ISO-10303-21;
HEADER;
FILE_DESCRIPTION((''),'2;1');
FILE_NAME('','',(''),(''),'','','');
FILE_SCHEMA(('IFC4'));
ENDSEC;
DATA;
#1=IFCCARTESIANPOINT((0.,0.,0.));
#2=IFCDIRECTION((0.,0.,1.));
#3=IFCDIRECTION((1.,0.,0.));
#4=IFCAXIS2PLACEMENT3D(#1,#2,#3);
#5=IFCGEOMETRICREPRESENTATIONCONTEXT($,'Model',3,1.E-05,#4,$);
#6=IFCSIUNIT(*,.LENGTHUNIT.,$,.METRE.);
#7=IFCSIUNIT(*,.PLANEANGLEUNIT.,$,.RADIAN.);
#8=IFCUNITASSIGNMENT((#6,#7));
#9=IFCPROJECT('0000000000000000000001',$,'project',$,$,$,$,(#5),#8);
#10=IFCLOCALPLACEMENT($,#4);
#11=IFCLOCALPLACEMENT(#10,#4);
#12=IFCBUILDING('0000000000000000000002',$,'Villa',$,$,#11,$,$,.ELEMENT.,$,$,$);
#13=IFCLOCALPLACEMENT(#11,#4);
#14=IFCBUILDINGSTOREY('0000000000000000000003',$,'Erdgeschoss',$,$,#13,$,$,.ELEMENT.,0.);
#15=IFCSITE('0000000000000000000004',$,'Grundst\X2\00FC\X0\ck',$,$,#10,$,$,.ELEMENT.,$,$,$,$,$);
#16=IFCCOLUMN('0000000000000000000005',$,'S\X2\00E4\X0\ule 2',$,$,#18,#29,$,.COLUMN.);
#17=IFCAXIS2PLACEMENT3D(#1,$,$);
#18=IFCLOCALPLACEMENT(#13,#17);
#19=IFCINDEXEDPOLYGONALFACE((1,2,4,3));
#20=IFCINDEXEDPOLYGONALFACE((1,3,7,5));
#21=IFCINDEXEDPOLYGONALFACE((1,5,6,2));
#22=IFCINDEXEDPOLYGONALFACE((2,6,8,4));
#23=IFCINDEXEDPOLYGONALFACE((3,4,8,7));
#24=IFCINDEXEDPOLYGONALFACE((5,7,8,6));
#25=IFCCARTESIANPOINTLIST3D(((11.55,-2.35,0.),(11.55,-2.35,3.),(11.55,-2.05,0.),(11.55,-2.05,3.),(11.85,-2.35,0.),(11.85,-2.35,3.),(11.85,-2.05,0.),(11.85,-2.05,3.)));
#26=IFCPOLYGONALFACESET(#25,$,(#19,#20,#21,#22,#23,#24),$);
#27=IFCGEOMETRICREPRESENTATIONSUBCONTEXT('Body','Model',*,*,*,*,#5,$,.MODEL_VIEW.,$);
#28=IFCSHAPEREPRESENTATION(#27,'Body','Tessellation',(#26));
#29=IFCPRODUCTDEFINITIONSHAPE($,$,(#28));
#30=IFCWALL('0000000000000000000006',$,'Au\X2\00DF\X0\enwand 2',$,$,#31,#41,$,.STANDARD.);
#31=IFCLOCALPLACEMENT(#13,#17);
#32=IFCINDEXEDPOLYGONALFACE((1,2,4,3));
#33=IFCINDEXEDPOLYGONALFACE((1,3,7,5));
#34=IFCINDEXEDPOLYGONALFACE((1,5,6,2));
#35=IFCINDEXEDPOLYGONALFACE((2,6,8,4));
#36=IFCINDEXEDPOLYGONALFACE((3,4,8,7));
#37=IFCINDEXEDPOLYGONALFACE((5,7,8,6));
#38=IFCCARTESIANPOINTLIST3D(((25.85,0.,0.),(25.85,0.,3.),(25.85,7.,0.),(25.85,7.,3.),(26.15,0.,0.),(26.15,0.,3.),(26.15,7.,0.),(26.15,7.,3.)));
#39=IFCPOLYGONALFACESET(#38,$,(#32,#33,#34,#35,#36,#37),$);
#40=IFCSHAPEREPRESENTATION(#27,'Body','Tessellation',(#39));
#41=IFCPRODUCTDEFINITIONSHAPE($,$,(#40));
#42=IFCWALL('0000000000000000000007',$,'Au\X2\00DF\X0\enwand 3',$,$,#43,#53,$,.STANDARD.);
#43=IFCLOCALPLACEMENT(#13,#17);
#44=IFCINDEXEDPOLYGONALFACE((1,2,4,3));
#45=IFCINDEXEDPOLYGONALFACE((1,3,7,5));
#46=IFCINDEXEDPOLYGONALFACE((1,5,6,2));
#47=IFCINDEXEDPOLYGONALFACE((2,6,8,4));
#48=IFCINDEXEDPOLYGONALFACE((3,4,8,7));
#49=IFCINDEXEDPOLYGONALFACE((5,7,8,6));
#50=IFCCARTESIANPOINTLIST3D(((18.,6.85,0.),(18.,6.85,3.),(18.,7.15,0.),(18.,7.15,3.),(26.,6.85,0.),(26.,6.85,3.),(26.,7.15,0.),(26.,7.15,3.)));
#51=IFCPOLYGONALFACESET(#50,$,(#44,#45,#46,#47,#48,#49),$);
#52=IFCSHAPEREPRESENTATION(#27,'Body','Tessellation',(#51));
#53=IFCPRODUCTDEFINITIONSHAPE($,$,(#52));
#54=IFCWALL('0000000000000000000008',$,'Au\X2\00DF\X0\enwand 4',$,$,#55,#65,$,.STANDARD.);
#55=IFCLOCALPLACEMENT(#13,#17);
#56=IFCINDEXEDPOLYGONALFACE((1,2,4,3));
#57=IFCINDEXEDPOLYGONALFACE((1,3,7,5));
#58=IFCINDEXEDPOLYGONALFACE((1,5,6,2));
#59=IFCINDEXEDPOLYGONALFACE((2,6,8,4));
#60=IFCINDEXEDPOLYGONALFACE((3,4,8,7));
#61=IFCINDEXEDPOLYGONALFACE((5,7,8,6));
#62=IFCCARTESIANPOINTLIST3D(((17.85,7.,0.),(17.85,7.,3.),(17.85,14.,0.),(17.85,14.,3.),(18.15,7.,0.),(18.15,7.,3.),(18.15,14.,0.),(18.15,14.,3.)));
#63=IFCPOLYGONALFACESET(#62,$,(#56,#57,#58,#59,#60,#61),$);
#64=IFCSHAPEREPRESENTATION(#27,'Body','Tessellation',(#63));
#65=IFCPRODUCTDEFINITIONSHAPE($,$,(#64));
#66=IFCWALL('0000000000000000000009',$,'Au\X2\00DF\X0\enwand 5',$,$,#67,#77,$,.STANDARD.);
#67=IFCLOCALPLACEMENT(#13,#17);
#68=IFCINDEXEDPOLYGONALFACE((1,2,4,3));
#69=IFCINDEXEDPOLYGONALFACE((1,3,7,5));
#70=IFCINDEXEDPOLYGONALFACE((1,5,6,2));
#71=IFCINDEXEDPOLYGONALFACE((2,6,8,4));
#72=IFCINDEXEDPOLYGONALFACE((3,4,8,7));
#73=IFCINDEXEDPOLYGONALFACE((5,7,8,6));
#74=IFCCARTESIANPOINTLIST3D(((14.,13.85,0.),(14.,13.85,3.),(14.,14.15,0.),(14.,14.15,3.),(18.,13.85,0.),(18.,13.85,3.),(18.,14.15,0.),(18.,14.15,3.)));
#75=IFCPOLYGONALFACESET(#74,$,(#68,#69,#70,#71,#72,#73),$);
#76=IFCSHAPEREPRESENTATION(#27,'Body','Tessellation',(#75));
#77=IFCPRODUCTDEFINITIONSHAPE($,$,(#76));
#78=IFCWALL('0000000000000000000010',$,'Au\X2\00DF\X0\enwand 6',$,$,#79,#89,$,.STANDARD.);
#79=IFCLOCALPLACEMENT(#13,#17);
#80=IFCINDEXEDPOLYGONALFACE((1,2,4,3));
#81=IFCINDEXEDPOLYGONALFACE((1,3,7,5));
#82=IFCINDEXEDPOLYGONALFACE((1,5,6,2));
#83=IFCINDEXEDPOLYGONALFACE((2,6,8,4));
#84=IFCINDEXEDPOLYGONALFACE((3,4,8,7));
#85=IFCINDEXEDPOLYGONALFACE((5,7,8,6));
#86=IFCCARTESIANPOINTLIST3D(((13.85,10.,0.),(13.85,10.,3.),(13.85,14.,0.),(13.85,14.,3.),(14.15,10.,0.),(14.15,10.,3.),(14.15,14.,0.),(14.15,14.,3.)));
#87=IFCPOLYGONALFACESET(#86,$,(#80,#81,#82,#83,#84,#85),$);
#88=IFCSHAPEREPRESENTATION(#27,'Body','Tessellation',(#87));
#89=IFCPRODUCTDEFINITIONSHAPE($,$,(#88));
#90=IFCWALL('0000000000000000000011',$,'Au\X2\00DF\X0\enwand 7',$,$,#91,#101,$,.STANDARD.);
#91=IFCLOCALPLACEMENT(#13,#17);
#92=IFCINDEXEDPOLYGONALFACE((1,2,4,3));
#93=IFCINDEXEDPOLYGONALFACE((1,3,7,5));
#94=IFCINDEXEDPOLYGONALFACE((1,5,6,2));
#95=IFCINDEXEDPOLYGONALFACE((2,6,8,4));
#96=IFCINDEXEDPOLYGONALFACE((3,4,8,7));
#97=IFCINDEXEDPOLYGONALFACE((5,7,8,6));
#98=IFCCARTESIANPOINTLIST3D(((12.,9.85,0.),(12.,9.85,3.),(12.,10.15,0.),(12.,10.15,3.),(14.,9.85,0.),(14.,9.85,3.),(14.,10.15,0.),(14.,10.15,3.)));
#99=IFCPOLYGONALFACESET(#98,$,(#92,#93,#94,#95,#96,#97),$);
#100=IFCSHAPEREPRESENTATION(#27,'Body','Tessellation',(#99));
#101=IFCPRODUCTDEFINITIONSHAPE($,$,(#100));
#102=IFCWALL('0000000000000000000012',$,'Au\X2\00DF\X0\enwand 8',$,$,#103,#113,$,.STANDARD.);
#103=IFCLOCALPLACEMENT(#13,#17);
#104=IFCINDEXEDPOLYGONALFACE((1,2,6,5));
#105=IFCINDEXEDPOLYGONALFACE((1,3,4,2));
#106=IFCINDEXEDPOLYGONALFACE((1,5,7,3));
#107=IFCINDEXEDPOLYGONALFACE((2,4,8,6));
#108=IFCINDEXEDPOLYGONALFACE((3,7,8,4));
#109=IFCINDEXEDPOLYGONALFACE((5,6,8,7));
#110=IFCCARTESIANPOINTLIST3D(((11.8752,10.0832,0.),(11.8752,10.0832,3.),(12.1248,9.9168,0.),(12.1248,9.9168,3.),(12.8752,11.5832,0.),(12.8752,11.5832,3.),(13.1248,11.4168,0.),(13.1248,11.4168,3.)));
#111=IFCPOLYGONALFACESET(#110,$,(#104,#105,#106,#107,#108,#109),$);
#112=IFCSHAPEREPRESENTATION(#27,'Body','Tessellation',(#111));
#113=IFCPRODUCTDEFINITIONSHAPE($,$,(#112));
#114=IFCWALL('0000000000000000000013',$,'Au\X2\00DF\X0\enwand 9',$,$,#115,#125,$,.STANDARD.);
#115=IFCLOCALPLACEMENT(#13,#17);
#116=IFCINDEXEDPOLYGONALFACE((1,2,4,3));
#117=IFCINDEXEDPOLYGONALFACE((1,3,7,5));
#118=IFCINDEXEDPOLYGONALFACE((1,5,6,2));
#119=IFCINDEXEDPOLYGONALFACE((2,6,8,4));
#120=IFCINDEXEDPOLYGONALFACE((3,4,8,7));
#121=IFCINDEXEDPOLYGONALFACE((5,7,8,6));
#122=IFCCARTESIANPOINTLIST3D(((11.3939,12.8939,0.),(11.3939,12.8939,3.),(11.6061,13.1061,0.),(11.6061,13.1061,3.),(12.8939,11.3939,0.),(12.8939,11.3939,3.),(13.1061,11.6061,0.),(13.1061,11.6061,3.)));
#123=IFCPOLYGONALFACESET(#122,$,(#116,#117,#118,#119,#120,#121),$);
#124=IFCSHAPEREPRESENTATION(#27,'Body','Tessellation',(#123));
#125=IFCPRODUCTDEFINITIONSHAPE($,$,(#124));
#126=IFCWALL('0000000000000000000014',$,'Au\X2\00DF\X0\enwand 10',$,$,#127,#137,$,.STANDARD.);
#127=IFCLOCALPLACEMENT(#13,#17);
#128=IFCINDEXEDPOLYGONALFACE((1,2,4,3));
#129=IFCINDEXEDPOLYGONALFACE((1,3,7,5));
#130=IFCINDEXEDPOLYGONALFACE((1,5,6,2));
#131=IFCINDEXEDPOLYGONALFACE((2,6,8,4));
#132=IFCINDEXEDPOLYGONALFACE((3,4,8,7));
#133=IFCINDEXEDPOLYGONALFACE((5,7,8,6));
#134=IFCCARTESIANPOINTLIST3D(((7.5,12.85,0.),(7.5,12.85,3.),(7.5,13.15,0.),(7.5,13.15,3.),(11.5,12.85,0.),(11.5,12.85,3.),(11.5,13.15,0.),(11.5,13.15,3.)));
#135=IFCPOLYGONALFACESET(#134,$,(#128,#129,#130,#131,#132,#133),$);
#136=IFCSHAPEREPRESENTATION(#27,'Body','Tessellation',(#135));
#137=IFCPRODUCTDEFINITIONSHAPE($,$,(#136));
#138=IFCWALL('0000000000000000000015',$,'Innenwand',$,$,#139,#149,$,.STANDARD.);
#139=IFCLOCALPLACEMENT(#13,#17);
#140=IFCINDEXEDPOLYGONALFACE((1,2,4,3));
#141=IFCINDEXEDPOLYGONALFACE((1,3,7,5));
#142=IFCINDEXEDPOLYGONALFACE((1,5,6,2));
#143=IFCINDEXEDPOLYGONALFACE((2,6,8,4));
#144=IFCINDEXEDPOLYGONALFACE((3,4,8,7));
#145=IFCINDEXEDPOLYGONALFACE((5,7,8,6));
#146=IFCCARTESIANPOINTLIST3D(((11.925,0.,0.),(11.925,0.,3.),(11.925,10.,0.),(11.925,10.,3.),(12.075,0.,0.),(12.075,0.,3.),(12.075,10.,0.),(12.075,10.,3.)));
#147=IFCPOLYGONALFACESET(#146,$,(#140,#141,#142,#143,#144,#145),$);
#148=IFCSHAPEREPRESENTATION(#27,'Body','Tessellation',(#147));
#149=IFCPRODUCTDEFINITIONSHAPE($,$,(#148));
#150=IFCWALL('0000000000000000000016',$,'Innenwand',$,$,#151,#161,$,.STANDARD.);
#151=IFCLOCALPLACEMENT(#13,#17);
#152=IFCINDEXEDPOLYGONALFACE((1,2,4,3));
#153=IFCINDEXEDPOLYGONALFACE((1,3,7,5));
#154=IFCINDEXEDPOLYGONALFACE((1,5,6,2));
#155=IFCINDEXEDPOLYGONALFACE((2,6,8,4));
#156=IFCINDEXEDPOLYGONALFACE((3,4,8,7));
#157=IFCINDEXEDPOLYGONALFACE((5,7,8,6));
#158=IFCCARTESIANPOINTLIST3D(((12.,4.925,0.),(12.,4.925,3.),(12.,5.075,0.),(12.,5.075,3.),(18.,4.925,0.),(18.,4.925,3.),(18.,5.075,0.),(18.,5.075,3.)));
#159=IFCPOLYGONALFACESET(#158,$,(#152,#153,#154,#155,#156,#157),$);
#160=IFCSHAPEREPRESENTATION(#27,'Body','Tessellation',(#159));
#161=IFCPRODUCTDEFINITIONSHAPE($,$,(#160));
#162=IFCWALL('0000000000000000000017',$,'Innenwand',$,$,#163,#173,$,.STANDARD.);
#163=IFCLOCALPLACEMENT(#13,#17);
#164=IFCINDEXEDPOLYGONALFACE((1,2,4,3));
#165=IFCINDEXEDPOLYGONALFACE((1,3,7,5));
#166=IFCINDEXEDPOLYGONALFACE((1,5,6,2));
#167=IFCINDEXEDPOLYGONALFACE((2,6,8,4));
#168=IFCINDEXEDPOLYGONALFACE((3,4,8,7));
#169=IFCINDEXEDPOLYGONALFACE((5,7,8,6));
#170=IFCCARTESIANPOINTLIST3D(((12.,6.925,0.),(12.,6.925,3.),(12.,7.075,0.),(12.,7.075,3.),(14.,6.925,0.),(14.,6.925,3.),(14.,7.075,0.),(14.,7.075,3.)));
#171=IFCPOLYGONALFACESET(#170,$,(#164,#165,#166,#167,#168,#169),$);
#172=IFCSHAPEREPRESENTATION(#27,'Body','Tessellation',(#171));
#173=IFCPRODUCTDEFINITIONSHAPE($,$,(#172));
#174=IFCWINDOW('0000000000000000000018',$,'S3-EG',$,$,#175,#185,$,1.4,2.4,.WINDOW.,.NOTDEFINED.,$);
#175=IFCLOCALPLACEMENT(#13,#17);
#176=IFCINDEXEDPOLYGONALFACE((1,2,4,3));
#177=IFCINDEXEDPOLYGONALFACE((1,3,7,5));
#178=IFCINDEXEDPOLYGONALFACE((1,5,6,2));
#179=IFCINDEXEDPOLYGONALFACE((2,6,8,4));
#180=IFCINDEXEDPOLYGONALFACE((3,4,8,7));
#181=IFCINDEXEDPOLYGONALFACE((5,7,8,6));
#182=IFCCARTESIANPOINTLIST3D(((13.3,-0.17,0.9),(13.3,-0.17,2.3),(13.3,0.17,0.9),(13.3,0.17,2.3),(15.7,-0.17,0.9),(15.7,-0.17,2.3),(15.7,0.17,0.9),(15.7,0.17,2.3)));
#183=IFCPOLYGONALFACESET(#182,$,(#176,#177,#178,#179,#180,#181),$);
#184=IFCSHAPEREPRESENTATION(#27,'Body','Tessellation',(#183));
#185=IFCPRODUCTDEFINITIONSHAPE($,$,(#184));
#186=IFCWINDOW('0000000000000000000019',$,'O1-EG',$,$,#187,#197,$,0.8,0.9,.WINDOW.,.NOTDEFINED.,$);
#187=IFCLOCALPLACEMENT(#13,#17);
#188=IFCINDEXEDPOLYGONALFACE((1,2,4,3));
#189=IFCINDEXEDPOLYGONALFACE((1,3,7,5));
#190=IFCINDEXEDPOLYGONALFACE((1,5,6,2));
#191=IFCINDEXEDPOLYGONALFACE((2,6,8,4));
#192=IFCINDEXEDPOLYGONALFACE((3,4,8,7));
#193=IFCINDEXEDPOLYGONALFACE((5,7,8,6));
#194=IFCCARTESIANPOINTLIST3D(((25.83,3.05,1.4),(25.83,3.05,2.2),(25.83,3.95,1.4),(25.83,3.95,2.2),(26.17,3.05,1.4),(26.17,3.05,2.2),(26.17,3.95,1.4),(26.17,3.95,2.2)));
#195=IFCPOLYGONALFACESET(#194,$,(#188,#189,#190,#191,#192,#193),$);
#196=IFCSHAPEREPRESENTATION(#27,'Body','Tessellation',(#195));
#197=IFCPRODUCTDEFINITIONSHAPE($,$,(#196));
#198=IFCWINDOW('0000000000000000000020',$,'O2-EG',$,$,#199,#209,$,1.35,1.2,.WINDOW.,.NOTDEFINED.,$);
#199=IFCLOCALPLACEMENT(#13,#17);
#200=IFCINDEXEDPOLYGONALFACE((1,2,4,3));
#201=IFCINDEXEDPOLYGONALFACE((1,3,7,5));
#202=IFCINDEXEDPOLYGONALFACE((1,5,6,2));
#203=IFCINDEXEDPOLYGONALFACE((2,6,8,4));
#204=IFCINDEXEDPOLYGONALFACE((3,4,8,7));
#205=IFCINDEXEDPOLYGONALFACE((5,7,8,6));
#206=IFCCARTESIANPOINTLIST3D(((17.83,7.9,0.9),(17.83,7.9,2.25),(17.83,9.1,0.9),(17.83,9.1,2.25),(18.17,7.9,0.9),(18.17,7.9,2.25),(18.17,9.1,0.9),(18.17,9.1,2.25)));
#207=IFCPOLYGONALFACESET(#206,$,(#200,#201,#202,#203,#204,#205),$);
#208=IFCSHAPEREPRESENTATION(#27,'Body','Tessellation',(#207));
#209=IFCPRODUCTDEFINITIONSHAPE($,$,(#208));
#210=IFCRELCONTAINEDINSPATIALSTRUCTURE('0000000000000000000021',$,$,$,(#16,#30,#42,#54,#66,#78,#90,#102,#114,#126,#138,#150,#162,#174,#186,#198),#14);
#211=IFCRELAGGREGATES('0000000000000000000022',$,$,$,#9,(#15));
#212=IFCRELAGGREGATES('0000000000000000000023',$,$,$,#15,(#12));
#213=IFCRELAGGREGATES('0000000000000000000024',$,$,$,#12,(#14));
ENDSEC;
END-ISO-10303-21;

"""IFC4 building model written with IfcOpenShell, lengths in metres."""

from ifc_helpers import new_model, si_unit, frame, frame_2d, origin_with_axes, origin_2d, place, context, subcontext, project, spatial, rectangle, extrude, element, save


model = new_model("IFC4")

# Units and contexts
model_context = context("Model", 3, precision=1e-05, world=origin_with_axes())
body_context = subcontext(model_context, "Body", "Model", "MODEL_VIEW")
ifc_project = project(units=[si_unit("LENGTHUNIT", "METRE"), si_unit("PLANEANGLEUNIT", "RADIAN")], contexts=[model_context])

# Site, building, storey
site_placement = place(None, origin_with_axes())
site = spatial("IfcSite", under=ifc_project, at=site_placement, Name="Grundstück", CompositionType="ELEMENT")
building_placement = place(site_placement, origin_with_axes())
building = spatial("IfcBuilding", under=site, at=building_placement, Name="Villa", CompositionType="ELEMENT")
storey_placement = place(building_placement, origin_with_axes())
storey = spatial("IfcBuildingStorey", under=building, at=storey_placement, Name="Erdgeschoss", CompositionType="ELEMENT", Elevation=0.0)

# Column
column_placement = place(storey_placement, frame((11.7, -2.2, 0.0), z_axis=(0.0, 0.0, 1.0), x_axis=(1.0, 0.0, 0.0)))
element("IfcColumn", 1, at=column_placement, inside=storey, Name="Säule 2", PredefinedType="COLUMN", context=body_context, shape_type="SweptSolid", body=[
    extrude(rectangle(XDim=0.3, YDim=0.3, at=origin_2d()), origin_with_axes(), (0.0, 0.0, 1.0), 3.0),
])

# Walls
wall_1_placement = place(storey_placement, frame((26.0, 0.0, 0.0), z_axis=(0.0, 0.0, 1.0), x_axis=(0.0, 1.0, 0.0)))
element("IfcWall", 2, at=wall_1_placement, inside=storey, Name="Außenwand 2", PredefinedType="STANDARD", context=body_context, shape_type="SweptSolid", body=[
    extrude(rectangle(XDim=7.0, YDim=0.3, at=frame_2d((3.5, 0.0))), origin_with_axes(), (0.0, 0.0, 1.0), 3.0),
])
wall_2_placement = place(storey_placement, frame((26.0, 7.0, 0.0), z_axis=(0.0, 0.0, 1.0), x_axis=(-1.0, 0.0, 0.0)))
element("IfcWall", 3, at=wall_2_placement, inside=storey, Name="Außenwand 3", PredefinedType="STANDARD", context=body_context, shape_type="SweptSolid", body=[
    extrude(rectangle(XDim=8.0, YDim=0.3, at=frame_2d((4.0, 0.0))), origin_with_axes(), (0.0, 0.0, 1.0), 3.0),
])
wall_3_placement = place(storey_placement, frame((18.0, 7.0, 0.0), z_axis=(0.0, 0.0, 1.0), x_axis=(0.0, 1.0, 0.0)))
element("IfcWall", 4, at=wall_3_placement, inside=storey, Name="Außenwand 4", PredefinedType="STANDARD", context=body_context, shape_type="SweptSolid", body=[
    extrude(rectangle(XDim=7.0, YDim=0.3, at=frame_2d((3.5, 0.0))), origin_with_axes(), (0.0, 0.0, 1.0), 3.0),
])
for number, where, z_axis, x_axis, name in (
    (5, (18.0, 14.0, 0.0), (0.0, 0.0, 1.0), (-1.0, 0.0, 0.0), "Außenwand 5"),
    (6, (14.0, 14.0, 0.0), (0.0, 0.0, 1.0), (0.0, -1.0, 0.0), "Außenwand 6"),
):
    element("IfcWall", number, at=place(storey_placement, frame(where, z_axis=z_axis, x_axis=x_axis)), inside=storey, Name=name, PredefinedType="STANDARD", context=body_context, shape_type="SweptSolid", body=[
        extrude(rectangle(XDim=4.0, YDim=0.3, at=frame_2d((2.0, 0.0))), origin_with_axes(), (0.0, 0.0, 1.0), 3.0),
    ])
wall_4_placement = place(storey_placement, frame((14.0, 10.0, 0.0), z_axis=(0.0, 0.0, 1.0), x_axis=(-1.0, 0.0, 0.0)))
element("IfcWall", 7, at=wall_4_placement, inside=storey, Name="Außenwand 7", PredefinedType="STANDARD", context=body_context, shape_type="SweptSolid", body=[
    extrude(rectangle(XDim=2.0, YDim=0.3, at=frame_2d((1.0, 0.0))), origin_with_axes(), (0.0, 0.0, 1.0), 3.0),
])
wall_5_placement = place(storey_placement, frame((12.0, 10.0, 0.0), z_axis=(0.0, 0.0, 1.0), x_axis=(0.5547, 0.83205, 0.0)))
element("IfcWall", 8, at=wall_5_placement, inside=storey, Name="Außenwand 8", PredefinedType="STANDARD", context=body_context, shape_type="SweptSolid", body=[
    extrude(rectangle(XDim=1.8028, YDim=0.3, at=frame_2d((0.9014, 0.0))), origin_with_axes(), (0.0, 0.0, 1.0), 3.0),
])
wall_6_placement = place(storey_placement, frame((13.0, 11.5, 0.0), z_axis=(0.0, 0.0, 1.0), x_axis=(-0.707107, 0.707107, 0.0)))
element("IfcWall", 9, at=wall_6_placement, inside=storey, Name="Außenwand 9", PredefinedType="STANDARD", context=body_context, shape_type="SweptSolid", body=[
    extrude(rectangle(XDim=2.1213, YDim=0.3, at=frame_2d((1.0607, 0.0))), origin_with_axes(), (0.0, 0.0, 1.0), 3.0),
])
wall_7_placement = place(storey_placement, frame((11.5, 13.0, 0.0), z_axis=(0.0, 0.0, 1.0), x_axis=(-1.0, 0.0, 0.0)))
element("IfcWall", 10, at=wall_7_placement, inside=storey, Name="Außenwand 10", PredefinedType="STANDARD", context=body_context, shape_type="SweptSolid", body=[
    extrude(rectangle(XDim=4.0, YDim=0.3, at=frame_2d((2.0, 0.0))), origin_with_axes(), (0.0, 0.0, 1.0), 3.0),
])
wall_8_placement = place(storey_placement, frame((12.0, 0.0, 0.0), z_axis=(0.0, 0.0, 1.0), x_axis=(0.0, 1.0, 0.0)))
element("IfcWall", 11, at=wall_8_placement, inside=storey, Name="Innenwand", PredefinedType="STANDARD", context=body_context, shape_type="SweptSolid", body=[
    extrude(rectangle(XDim=10.0, YDim=0.15, at=frame_2d((5.0, 0.0))), origin_with_axes(), (0.0, 0.0, 1.0), 3.0),
])
wall_9_placement = place(storey_placement, frame((12.0, 5.0, 0.0), z_axis=(0.0, 0.0, 1.0), x_axis=(1.0, 0.0, 0.0)))
element("IfcWall", 12, at=wall_9_placement, inside=storey, Name="Innenwand", PredefinedType="STANDARD", context=body_context, shape_type="SweptSolid", body=[
    extrude(rectangle(XDim=6.0, YDim=0.15, at=frame_2d((3.0, 0.0))), origin_with_axes(), (0.0, 0.0, 1.0), 3.0),
])
wall_10_placement = place(storey_placement, frame((12.0, 7.0, 0.0), z_axis=(0.0, 0.0, 1.0), x_axis=(1.0, 0.0, 0.0)))
element("IfcWall", 13, at=wall_10_placement, inside=storey, Name="Innenwand", PredefinedType="STANDARD", context=body_context, shape_type="SweptSolid", body=[
    extrude(rectangle(XDim=2.0, YDim=0.15, at=frame_2d((1.0, 0.0))), origin_with_axes(), (0.0, 0.0, 1.0), 3.0),
])

# Windows
window_1_placement = place(storey_placement, frame((14.5, 0.0, 0.9), z_axis=(0.0, 0.0, 1.0), x_axis=(1.0, 0.0, 0.0)))
element("IfcWindow", 14, at=window_1_placement, inside=storey, Name="S3-EG", OverallHeight=1.4, OverallWidth=2.4, PartitioningType="NOTDEFINED", PredefinedType="WINDOW", context=body_context, shape_type="SweptSolid", body=[
    extrude(rectangle(XDim=2.4, YDim=0.34, at=origin_2d()), origin_with_axes(), (0.0, 0.0, 1.0), 1.4),
])
window_2_placement = place(storey_placement, frame((26.0, 3.5, 1.4), z_axis=(0.0, 0.0, 1.0), x_axis=(0.0, 1.0, 0.0)))
element("IfcWindow", 15, at=window_2_placement, inside=storey, Name="O1-EG", OverallHeight=0.8, OverallWidth=0.9, PartitioningType="NOTDEFINED", PredefinedType="WINDOW", context=body_context, shape_type="SweptSolid", body=[
    extrude(rectangle(XDim=0.9, YDim=0.34, at=origin_2d()), origin_with_axes(), (0.0, 0.0, 1.0), 0.8),
])
window_3_placement = place(storey_placement, frame((18.0, 8.5, 0.9), z_axis=(0.0, 0.0, 1.0), x_axis=(0.0, 1.0, 0.0)))
element("IfcWindow", 16, at=window_3_placement, inside=storey, Name="O2-EG", OverallHeight=1.35, OverallWidth=1.2, PartitioningType="NOTDEFINED", PredefinedType="WINDOW", context=body_context, shape_type="SweptSolid", body=[
    extrude(rectangle(XDim=1.2, YDim=0.34, at=origin_2d()), origin_with_axes(), (0.0, 0.0, 1.0), 1.35),
])

save(model, "model.ifc")
